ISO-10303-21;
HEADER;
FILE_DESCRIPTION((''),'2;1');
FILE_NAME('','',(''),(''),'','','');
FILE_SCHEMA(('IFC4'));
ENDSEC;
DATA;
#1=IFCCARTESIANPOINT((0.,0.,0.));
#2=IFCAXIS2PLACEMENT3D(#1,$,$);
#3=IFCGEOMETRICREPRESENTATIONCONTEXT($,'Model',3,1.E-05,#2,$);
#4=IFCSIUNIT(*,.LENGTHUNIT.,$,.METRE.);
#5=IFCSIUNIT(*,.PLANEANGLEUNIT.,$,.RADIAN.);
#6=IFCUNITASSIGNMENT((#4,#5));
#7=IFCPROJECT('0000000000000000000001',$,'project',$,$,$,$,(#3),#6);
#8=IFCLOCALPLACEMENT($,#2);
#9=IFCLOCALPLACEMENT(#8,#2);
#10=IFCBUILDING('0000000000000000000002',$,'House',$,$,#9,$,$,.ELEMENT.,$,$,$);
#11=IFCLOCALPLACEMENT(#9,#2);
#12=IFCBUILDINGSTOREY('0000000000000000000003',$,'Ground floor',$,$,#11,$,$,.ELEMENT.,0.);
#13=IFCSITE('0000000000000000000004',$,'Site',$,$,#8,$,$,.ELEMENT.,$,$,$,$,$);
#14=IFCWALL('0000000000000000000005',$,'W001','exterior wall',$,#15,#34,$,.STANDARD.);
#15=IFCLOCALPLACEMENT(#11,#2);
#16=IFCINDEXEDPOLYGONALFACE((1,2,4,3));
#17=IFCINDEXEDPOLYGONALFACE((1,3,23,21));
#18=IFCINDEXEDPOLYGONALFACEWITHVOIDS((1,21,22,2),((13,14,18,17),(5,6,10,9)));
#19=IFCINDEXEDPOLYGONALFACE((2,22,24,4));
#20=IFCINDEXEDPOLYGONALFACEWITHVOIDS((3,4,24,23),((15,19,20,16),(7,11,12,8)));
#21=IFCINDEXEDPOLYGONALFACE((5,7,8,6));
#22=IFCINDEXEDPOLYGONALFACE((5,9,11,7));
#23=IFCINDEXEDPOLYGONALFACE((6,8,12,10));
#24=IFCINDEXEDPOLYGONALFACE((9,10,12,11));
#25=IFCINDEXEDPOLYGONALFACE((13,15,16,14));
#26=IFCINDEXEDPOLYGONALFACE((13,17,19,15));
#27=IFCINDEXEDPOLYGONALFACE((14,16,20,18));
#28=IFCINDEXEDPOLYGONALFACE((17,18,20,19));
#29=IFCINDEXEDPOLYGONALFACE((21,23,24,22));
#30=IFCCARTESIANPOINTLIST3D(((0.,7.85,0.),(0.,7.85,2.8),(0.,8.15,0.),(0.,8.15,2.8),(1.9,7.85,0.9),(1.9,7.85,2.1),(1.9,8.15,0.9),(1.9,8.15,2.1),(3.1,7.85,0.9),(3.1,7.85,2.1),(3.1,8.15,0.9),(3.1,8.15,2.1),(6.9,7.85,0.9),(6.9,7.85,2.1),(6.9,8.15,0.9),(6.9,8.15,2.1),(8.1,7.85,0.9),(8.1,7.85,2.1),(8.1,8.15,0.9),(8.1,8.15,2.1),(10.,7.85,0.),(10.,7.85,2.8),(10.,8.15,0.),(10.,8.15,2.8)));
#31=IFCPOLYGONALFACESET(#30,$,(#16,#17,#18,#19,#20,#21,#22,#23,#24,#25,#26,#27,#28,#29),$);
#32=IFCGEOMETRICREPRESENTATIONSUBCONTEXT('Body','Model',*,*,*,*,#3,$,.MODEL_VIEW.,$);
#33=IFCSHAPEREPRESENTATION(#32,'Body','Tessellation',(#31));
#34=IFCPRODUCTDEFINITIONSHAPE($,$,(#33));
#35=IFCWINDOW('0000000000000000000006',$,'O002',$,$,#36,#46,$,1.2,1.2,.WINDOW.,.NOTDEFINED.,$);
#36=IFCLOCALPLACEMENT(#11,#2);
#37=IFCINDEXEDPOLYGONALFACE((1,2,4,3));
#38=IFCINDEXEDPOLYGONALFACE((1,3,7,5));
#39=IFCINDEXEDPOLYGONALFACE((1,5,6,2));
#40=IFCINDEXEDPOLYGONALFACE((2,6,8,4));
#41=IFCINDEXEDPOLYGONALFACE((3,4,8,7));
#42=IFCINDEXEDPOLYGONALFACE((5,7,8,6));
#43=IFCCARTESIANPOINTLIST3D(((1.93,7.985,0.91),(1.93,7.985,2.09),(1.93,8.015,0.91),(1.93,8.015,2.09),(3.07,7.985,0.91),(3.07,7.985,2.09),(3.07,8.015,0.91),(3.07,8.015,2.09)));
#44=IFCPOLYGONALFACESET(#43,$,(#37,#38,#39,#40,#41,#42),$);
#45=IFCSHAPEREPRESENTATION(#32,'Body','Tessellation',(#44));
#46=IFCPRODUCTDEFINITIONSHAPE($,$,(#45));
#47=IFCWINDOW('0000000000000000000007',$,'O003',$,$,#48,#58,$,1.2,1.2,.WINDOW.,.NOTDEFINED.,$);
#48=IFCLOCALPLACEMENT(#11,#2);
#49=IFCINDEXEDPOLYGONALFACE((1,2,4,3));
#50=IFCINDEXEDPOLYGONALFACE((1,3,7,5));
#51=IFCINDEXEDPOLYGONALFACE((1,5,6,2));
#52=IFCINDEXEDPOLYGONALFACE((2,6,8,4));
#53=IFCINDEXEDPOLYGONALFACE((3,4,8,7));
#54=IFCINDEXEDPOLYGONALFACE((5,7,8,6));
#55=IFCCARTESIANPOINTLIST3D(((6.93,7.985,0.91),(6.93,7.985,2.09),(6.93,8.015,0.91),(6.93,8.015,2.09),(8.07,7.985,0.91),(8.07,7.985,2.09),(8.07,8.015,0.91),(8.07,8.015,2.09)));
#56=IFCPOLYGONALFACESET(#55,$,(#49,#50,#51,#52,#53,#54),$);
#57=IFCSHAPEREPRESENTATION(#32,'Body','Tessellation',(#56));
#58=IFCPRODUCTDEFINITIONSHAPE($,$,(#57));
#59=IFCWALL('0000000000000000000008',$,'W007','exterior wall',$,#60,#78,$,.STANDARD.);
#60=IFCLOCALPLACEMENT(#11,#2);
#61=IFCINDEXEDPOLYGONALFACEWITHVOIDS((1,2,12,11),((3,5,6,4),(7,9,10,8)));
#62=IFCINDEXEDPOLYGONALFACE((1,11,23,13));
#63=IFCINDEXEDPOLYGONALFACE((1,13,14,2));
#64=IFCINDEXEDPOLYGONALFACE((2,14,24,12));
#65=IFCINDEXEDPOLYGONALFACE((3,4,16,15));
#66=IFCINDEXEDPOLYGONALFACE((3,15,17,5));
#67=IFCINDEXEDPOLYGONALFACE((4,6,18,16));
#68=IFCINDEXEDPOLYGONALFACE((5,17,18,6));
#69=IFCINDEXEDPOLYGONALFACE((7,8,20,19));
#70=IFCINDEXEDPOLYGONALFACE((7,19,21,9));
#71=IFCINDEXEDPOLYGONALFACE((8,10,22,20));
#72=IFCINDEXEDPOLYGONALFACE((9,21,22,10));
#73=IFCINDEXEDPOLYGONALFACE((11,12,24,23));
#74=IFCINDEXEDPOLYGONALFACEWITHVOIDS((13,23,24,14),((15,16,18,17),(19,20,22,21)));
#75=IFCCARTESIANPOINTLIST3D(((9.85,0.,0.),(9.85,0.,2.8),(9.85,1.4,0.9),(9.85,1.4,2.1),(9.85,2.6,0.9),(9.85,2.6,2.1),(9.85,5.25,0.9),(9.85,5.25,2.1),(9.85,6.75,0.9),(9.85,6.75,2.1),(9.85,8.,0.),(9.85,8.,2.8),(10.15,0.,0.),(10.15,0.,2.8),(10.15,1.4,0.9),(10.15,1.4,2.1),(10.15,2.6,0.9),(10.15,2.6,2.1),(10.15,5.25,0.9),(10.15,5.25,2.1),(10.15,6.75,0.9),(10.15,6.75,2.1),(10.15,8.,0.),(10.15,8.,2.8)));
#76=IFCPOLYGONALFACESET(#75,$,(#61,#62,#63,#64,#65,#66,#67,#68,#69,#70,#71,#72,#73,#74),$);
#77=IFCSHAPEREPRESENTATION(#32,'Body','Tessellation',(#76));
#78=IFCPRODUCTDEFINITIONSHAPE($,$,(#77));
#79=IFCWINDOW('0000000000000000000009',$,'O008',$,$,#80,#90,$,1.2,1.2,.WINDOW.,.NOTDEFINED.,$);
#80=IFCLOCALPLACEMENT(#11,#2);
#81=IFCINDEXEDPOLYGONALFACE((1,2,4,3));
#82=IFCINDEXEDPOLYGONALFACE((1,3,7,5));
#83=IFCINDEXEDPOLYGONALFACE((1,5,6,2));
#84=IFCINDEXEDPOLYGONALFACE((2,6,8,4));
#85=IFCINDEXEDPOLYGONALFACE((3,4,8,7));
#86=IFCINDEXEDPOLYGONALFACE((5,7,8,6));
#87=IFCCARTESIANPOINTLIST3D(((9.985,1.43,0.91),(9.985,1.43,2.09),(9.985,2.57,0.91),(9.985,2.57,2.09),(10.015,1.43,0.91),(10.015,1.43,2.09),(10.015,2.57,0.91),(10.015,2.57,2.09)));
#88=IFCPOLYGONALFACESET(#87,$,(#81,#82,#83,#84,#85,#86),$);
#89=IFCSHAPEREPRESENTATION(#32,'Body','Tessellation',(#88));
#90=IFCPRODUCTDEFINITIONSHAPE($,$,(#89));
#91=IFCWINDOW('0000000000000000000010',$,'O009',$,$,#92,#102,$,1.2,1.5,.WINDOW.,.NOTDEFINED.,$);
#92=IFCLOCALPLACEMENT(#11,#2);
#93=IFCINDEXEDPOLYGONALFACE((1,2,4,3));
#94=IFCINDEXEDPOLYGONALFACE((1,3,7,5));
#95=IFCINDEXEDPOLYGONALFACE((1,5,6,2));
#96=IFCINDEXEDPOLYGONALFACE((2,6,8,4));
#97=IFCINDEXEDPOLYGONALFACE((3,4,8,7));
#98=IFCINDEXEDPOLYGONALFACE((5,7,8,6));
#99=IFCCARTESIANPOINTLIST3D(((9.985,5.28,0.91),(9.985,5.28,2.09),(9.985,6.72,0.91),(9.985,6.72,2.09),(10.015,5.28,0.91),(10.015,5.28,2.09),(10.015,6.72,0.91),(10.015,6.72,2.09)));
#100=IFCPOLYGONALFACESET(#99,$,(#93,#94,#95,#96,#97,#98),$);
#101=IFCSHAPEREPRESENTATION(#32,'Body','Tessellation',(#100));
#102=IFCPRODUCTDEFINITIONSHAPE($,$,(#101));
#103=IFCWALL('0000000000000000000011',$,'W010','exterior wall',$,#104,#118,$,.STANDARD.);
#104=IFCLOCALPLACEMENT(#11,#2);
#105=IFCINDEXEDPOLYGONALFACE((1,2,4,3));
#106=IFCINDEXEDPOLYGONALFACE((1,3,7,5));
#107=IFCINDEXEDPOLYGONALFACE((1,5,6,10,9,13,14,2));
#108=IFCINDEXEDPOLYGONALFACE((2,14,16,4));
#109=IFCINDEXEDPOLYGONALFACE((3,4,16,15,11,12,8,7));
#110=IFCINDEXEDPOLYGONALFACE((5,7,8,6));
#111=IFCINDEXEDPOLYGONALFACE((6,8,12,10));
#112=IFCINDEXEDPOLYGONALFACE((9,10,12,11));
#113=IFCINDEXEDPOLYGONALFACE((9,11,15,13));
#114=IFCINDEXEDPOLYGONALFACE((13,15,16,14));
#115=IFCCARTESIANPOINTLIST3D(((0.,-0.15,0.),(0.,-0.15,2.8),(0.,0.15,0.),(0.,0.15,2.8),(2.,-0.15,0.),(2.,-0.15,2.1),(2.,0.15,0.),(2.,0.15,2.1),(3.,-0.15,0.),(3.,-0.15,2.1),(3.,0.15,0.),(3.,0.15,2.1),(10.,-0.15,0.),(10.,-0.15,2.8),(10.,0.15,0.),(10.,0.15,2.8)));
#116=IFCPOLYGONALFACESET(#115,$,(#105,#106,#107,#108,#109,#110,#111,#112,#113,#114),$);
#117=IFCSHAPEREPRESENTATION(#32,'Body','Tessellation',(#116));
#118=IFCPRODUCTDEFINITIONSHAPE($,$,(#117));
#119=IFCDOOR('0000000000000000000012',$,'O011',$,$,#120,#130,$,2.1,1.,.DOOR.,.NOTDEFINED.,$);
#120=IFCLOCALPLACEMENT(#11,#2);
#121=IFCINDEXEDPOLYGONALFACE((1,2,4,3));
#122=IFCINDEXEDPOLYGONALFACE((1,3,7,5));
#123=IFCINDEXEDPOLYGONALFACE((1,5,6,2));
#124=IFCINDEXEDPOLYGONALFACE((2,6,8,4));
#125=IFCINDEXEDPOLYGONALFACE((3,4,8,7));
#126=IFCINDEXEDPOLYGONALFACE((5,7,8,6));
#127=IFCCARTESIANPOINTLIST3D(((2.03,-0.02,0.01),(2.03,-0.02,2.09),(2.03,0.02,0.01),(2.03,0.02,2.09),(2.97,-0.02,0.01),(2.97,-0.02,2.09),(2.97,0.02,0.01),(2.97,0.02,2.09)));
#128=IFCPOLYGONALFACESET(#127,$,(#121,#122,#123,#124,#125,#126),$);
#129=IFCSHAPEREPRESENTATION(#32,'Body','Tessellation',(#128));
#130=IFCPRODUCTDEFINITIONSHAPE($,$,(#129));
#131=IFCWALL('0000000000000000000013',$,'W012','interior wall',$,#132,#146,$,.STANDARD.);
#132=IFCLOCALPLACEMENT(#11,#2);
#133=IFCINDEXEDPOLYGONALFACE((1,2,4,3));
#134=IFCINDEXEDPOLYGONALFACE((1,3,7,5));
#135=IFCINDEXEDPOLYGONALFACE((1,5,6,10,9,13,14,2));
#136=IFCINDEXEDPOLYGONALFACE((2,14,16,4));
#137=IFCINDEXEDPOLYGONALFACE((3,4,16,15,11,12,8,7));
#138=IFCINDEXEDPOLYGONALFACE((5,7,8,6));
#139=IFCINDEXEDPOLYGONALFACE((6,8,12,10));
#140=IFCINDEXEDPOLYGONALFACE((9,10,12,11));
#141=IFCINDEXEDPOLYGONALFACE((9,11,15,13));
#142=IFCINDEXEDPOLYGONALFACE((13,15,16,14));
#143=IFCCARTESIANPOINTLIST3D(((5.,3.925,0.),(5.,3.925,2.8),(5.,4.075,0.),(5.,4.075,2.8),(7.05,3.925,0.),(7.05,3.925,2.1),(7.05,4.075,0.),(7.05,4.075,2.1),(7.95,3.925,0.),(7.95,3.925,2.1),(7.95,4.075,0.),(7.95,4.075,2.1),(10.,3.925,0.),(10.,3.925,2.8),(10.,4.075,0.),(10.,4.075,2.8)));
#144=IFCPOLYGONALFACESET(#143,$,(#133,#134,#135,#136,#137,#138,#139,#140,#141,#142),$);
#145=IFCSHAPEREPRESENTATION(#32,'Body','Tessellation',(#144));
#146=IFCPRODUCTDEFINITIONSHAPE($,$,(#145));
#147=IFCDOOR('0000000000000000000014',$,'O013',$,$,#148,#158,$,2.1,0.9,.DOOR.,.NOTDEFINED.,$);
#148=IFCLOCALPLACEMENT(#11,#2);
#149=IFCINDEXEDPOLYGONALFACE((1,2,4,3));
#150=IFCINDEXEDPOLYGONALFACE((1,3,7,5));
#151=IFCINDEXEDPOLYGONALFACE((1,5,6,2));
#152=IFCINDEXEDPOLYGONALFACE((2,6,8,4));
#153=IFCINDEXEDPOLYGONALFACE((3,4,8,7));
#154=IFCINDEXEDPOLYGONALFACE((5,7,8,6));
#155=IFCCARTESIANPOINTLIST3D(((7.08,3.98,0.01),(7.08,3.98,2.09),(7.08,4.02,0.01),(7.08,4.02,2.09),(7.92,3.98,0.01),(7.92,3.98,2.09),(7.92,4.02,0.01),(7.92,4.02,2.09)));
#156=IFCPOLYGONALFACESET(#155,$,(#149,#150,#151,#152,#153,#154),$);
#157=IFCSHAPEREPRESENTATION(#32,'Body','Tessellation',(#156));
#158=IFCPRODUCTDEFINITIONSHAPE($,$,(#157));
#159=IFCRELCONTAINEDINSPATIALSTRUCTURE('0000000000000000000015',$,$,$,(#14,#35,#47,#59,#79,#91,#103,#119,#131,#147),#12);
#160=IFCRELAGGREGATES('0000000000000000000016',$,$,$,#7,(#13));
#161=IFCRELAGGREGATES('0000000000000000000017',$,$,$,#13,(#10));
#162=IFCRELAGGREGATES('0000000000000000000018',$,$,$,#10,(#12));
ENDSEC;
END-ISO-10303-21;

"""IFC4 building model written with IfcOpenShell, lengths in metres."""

from ifc_helpers import new_model, si_unit, frame, origin, origin_2d, place, context, subcontext, project, spatial, rectangle, extrude, element, fill, save


model = new_model("IFC4")

# Units and contexts
model_context = context("Model", 3, precision=1e-05, world=origin())
body_context = subcontext(model_context, "Body", "Model", "MODEL_VIEW")
ifc_project = project(units=[si_unit("LENGTHUNIT", "METRE"), si_unit("PLANEANGLEUNIT", "RADIAN")], contexts=[model_context])

# Site, building, storey
site_placement = place(None, origin())
site = spatial("IfcSite", under=ifc_project, at=site_placement, Name="Site", CompositionType="ELEMENT")
building_placement = place(site_placement, origin())
building = spatial("IfcBuilding", under=site, at=building_placement, Name="House", CompositionType="ELEMENT")
storey_placement = place(building_placement, origin())
storey = spatial("IfcBuildingStorey", under=building, at=storey_placement, Name="Ground floor", CompositionType="ELEMENT", Elevation=0.0)

# Walls, openings, windows
wall_1_placement = place(storey_placement, frame((5.0, 8.0, 0.0), z_axis=(0.0, 0.0, 1.0), x_axis=(1.0, 0.0, 0.0)))
wall_1 = element("IfcWall", 1, at=wall_1_placement, inside=storey, Name="W001", Description="exterior wall", PredefinedType="STANDARD", context=body_context, shape_type="SweptSolid", body=[
    extrude(rectangle(XDim=10.0, YDim=0.3, at=origin_2d()), origin(), (0.0, 0.0, 1.0), 2.8),
])
opening_1_placement = place(wall_1_placement, frame((-2.5, 0.0, 0.9)))
opening_1 = element("IfcOpeningElement", 2, at=opening_1_placement, cuts=wall_1, PredefinedType="OPENING", context=body_context, shape_type="SweptSolid", body=[
    extrude(rectangle(XDim=1.2, YDim=0.36, at=origin_2d()), origin(), (0.0, 0.0, 1.0), 1.2),
])
opening_2_placement = place(wall_1_placement, frame((2.5, 0.0, 0.9)))
opening_2 = element("IfcOpeningElement", 3, at=opening_2_placement, cuts=wall_1, PredefinedType="OPENING", context=body_context, shape_type="SweptSolid", body=[
    extrude(rectangle(XDim=1.2, YDim=0.36, at=origin_2d()), origin(), (0.0, 0.0, 1.0), 1.2),
])
window_1_placement = place(wall_1_placement, frame((-2.5, 0.0, 0.9)))
window_1 = element("IfcWindow", 4, at=window_1_placement, inside=storey, Name="O002", OverallHeight=1.2, OverallWidth=1.2, PartitioningType="NOTDEFINED", PredefinedType="WINDOW", context=body_context, shape_type="SweptSolid", body=[
    extrude(rectangle(XDim=1.14, YDim=0.03, at=origin_2d()), frame((0.0, 0.0, 0.01)), (0.0, 0.0, 1.0), 1.18),
])
fill(opening_1, window_1)
window_2_placement = place(wall_1_placement, frame((2.5, 0.0, 0.9)))
window_2 = element("IfcWindow", 5, at=window_2_placement, inside=storey, Name="O003", OverallHeight=1.2, OverallWidth=1.2, PartitioningType="NOTDEFINED", PredefinedType="WINDOW", context=body_context, shape_type="SweptSolid", body=[
    extrude(rectangle(XDim=1.14, YDim=0.03, at=origin_2d()), frame((0.0, 0.0, 0.01)), (0.0, 0.0, 1.0), 1.18),
])
fill(opening_2, window_2)
wall_2_placement = place(storey_placement, frame((10.0, 4.0, 0.0), z_axis=(0.0, 0.0, 1.0), x_axis=(0.0, 1.0, 0.0)))
wall_2 = element("IfcWall", 6, at=wall_2_placement, inside=storey, Name="W007", Description="exterior wall", PredefinedType="STANDARD", context=body_context, shape_type="SweptSolid", body=[
    extrude(rectangle(XDim=8.0, YDim=0.3, at=origin_2d()), origin(), (0.0, 0.0, 1.0), 2.8),
])
opening_3_placement = place(wall_2_placement, frame((-2.0, 0.0, 0.9)))
opening_3 = element("IfcOpeningElement", 7, at=opening_3_placement, cuts=wall_2, PredefinedType="OPENING", context=body_context, shape_type="SweptSolid", body=[
    extrude(rectangle(XDim=1.2, YDim=0.36, at=origin_2d()), origin(), (0.0, 0.0, 1.0), 1.2),
])
opening_4_placement = place(wall_2_placement, frame((2.0, 0.0, 0.9)))
opening_4 = element("IfcOpeningElement", 8, at=opening_4_placement, cuts=wall_2, PredefinedType="OPENING", context=body_context, shape_type="SweptSolid", body=[
    extrude(rectangle(XDim=1.5, YDim=0.36, at=origin_2d()), origin(), (0.0, 0.0, 1.0), 1.2),
])
window_3_placement = place(wall_2_placement, frame((-2.0, 0.0, 0.9)))
window_3 = element("IfcWindow", 9, at=window_3_placement, inside=storey, Name="O008", OverallHeight=1.2, OverallWidth=1.2, PartitioningType="NOTDEFINED", PredefinedType="WINDOW", context=body_context, shape_type="SweptSolid", body=[
    extrude(rectangle(XDim=1.14, YDim=0.03, at=origin_2d()), frame((0.0, 0.0, 0.01)), (0.0, 0.0, 1.0), 1.18),
])
fill(opening_3, window_3)
window_4_placement = place(wall_2_placement, frame((2.0, 0.0, 0.9)))
window_4 = element("IfcWindow", 10, at=window_4_placement, inside=storey, Name="O009", OverallHeight=1.2, OverallWidth=1.5, PartitioningType="NOTDEFINED", PredefinedType="WINDOW", context=body_context, shape_type="SweptSolid", body=[
    extrude(rectangle(XDim=1.44, YDim=0.03, at=origin_2d()), frame((0.0, 0.0, 0.01)), (0.0, 0.0, 1.0), 1.18),
])
fill(opening_4, window_4)

# Walls, openings, doors
wall_3_placement = place(storey_placement, frame((5.0, 0.0, 0.0), z_axis=(0.0, 0.0, 1.0), x_axis=(1.0, 0.0, 0.0)))
wall_3 = element("IfcWall", 11, at=wall_3_placement, inside=storey, Name="W010", Description="exterior wall", PredefinedType="STANDARD", context=body_context, shape_type="SweptSolid", body=[
    extrude(rectangle(XDim=10.0, YDim=0.3, at=origin_2d()), origin(), (0.0, 0.0, 1.0), 2.8),
])
opening_5_placement = place(wall_3_placement, frame((-2.5, 0.0, 0.0)))
opening_5 = element("IfcOpeningElement", 12, at=opening_5_placement, cuts=wall_3, PredefinedType="OPENING", context=body_context, shape_type="SweptSolid", body=[
    extrude(rectangle(XDim=1.0, YDim=0.36, at=origin_2d()), origin(), (0.0, 0.0, 1.0), 2.1),
])
door_1_placement = place(wall_3_placement, frame((-2.5, 0.0, 0.0)))
door_1 = element("IfcDoor", 13, at=door_1_placement, inside=storey, Name="O011", OperationType="NOTDEFINED", OverallHeight=2.1, OverallWidth=1.0, PredefinedType="DOOR", context=body_context, shape_type="SweptSolid", body=[
    extrude(rectangle(XDim=0.94, YDim=0.04, at=origin_2d()), frame((0.0, 0.0, 0.01)), (0.0, 0.0, 1.0), 2.08),
])
fill(opening_5, door_1)
wall_4_placement = place(storey_placement, frame((7.5, 4.0, 0.0), z_axis=(0.0, 0.0, 1.0), x_axis=(1.0, 0.0, 0.0)))
wall_4 = element("IfcWall", 14, at=wall_4_placement, inside=storey, Name="W012", Description="interior wall", PredefinedType="STANDARD", context=body_context, shape_type="SweptSolid", body=[
    extrude(rectangle(XDim=5.0, YDim=0.15, at=origin_2d()), origin(), (0.0, 0.0, 1.0), 2.8),
])
opening_6_placement = place(wall_4_placement, origin())
opening_6 = element("IfcOpeningElement", 15, at=opening_6_placement, cuts=wall_4, PredefinedType="OPENING", context=body_context, shape_type="SweptSolid", body=[
    extrude(rectangle(XDim=0.9, YDim=0.18, at=origin_2d()), origin(), (0.0, 0.0, 1.0), 2.1),
])
door_2_placement = place(wall_4_placement, origin())
door_2 = element("IfcDoor", 16, at=door_2_placement, inside=storey, Name="O013", OperationType="NOTDEFINED", OverallHeight=2.1, OverallWidth=0.9, PredefinedType="DOOR", context=body_context, shape_type="SweptSolid", body=[
    extrude(rectangle(XDim=0.84, YDim=0.04, at=origin_2d()), frame((0.0, 0.0, 0.01)), (0.0, 0.0, 1.0), 2.08),
])
fill(opening_6, door_2)

save(model, "model.ifc")
